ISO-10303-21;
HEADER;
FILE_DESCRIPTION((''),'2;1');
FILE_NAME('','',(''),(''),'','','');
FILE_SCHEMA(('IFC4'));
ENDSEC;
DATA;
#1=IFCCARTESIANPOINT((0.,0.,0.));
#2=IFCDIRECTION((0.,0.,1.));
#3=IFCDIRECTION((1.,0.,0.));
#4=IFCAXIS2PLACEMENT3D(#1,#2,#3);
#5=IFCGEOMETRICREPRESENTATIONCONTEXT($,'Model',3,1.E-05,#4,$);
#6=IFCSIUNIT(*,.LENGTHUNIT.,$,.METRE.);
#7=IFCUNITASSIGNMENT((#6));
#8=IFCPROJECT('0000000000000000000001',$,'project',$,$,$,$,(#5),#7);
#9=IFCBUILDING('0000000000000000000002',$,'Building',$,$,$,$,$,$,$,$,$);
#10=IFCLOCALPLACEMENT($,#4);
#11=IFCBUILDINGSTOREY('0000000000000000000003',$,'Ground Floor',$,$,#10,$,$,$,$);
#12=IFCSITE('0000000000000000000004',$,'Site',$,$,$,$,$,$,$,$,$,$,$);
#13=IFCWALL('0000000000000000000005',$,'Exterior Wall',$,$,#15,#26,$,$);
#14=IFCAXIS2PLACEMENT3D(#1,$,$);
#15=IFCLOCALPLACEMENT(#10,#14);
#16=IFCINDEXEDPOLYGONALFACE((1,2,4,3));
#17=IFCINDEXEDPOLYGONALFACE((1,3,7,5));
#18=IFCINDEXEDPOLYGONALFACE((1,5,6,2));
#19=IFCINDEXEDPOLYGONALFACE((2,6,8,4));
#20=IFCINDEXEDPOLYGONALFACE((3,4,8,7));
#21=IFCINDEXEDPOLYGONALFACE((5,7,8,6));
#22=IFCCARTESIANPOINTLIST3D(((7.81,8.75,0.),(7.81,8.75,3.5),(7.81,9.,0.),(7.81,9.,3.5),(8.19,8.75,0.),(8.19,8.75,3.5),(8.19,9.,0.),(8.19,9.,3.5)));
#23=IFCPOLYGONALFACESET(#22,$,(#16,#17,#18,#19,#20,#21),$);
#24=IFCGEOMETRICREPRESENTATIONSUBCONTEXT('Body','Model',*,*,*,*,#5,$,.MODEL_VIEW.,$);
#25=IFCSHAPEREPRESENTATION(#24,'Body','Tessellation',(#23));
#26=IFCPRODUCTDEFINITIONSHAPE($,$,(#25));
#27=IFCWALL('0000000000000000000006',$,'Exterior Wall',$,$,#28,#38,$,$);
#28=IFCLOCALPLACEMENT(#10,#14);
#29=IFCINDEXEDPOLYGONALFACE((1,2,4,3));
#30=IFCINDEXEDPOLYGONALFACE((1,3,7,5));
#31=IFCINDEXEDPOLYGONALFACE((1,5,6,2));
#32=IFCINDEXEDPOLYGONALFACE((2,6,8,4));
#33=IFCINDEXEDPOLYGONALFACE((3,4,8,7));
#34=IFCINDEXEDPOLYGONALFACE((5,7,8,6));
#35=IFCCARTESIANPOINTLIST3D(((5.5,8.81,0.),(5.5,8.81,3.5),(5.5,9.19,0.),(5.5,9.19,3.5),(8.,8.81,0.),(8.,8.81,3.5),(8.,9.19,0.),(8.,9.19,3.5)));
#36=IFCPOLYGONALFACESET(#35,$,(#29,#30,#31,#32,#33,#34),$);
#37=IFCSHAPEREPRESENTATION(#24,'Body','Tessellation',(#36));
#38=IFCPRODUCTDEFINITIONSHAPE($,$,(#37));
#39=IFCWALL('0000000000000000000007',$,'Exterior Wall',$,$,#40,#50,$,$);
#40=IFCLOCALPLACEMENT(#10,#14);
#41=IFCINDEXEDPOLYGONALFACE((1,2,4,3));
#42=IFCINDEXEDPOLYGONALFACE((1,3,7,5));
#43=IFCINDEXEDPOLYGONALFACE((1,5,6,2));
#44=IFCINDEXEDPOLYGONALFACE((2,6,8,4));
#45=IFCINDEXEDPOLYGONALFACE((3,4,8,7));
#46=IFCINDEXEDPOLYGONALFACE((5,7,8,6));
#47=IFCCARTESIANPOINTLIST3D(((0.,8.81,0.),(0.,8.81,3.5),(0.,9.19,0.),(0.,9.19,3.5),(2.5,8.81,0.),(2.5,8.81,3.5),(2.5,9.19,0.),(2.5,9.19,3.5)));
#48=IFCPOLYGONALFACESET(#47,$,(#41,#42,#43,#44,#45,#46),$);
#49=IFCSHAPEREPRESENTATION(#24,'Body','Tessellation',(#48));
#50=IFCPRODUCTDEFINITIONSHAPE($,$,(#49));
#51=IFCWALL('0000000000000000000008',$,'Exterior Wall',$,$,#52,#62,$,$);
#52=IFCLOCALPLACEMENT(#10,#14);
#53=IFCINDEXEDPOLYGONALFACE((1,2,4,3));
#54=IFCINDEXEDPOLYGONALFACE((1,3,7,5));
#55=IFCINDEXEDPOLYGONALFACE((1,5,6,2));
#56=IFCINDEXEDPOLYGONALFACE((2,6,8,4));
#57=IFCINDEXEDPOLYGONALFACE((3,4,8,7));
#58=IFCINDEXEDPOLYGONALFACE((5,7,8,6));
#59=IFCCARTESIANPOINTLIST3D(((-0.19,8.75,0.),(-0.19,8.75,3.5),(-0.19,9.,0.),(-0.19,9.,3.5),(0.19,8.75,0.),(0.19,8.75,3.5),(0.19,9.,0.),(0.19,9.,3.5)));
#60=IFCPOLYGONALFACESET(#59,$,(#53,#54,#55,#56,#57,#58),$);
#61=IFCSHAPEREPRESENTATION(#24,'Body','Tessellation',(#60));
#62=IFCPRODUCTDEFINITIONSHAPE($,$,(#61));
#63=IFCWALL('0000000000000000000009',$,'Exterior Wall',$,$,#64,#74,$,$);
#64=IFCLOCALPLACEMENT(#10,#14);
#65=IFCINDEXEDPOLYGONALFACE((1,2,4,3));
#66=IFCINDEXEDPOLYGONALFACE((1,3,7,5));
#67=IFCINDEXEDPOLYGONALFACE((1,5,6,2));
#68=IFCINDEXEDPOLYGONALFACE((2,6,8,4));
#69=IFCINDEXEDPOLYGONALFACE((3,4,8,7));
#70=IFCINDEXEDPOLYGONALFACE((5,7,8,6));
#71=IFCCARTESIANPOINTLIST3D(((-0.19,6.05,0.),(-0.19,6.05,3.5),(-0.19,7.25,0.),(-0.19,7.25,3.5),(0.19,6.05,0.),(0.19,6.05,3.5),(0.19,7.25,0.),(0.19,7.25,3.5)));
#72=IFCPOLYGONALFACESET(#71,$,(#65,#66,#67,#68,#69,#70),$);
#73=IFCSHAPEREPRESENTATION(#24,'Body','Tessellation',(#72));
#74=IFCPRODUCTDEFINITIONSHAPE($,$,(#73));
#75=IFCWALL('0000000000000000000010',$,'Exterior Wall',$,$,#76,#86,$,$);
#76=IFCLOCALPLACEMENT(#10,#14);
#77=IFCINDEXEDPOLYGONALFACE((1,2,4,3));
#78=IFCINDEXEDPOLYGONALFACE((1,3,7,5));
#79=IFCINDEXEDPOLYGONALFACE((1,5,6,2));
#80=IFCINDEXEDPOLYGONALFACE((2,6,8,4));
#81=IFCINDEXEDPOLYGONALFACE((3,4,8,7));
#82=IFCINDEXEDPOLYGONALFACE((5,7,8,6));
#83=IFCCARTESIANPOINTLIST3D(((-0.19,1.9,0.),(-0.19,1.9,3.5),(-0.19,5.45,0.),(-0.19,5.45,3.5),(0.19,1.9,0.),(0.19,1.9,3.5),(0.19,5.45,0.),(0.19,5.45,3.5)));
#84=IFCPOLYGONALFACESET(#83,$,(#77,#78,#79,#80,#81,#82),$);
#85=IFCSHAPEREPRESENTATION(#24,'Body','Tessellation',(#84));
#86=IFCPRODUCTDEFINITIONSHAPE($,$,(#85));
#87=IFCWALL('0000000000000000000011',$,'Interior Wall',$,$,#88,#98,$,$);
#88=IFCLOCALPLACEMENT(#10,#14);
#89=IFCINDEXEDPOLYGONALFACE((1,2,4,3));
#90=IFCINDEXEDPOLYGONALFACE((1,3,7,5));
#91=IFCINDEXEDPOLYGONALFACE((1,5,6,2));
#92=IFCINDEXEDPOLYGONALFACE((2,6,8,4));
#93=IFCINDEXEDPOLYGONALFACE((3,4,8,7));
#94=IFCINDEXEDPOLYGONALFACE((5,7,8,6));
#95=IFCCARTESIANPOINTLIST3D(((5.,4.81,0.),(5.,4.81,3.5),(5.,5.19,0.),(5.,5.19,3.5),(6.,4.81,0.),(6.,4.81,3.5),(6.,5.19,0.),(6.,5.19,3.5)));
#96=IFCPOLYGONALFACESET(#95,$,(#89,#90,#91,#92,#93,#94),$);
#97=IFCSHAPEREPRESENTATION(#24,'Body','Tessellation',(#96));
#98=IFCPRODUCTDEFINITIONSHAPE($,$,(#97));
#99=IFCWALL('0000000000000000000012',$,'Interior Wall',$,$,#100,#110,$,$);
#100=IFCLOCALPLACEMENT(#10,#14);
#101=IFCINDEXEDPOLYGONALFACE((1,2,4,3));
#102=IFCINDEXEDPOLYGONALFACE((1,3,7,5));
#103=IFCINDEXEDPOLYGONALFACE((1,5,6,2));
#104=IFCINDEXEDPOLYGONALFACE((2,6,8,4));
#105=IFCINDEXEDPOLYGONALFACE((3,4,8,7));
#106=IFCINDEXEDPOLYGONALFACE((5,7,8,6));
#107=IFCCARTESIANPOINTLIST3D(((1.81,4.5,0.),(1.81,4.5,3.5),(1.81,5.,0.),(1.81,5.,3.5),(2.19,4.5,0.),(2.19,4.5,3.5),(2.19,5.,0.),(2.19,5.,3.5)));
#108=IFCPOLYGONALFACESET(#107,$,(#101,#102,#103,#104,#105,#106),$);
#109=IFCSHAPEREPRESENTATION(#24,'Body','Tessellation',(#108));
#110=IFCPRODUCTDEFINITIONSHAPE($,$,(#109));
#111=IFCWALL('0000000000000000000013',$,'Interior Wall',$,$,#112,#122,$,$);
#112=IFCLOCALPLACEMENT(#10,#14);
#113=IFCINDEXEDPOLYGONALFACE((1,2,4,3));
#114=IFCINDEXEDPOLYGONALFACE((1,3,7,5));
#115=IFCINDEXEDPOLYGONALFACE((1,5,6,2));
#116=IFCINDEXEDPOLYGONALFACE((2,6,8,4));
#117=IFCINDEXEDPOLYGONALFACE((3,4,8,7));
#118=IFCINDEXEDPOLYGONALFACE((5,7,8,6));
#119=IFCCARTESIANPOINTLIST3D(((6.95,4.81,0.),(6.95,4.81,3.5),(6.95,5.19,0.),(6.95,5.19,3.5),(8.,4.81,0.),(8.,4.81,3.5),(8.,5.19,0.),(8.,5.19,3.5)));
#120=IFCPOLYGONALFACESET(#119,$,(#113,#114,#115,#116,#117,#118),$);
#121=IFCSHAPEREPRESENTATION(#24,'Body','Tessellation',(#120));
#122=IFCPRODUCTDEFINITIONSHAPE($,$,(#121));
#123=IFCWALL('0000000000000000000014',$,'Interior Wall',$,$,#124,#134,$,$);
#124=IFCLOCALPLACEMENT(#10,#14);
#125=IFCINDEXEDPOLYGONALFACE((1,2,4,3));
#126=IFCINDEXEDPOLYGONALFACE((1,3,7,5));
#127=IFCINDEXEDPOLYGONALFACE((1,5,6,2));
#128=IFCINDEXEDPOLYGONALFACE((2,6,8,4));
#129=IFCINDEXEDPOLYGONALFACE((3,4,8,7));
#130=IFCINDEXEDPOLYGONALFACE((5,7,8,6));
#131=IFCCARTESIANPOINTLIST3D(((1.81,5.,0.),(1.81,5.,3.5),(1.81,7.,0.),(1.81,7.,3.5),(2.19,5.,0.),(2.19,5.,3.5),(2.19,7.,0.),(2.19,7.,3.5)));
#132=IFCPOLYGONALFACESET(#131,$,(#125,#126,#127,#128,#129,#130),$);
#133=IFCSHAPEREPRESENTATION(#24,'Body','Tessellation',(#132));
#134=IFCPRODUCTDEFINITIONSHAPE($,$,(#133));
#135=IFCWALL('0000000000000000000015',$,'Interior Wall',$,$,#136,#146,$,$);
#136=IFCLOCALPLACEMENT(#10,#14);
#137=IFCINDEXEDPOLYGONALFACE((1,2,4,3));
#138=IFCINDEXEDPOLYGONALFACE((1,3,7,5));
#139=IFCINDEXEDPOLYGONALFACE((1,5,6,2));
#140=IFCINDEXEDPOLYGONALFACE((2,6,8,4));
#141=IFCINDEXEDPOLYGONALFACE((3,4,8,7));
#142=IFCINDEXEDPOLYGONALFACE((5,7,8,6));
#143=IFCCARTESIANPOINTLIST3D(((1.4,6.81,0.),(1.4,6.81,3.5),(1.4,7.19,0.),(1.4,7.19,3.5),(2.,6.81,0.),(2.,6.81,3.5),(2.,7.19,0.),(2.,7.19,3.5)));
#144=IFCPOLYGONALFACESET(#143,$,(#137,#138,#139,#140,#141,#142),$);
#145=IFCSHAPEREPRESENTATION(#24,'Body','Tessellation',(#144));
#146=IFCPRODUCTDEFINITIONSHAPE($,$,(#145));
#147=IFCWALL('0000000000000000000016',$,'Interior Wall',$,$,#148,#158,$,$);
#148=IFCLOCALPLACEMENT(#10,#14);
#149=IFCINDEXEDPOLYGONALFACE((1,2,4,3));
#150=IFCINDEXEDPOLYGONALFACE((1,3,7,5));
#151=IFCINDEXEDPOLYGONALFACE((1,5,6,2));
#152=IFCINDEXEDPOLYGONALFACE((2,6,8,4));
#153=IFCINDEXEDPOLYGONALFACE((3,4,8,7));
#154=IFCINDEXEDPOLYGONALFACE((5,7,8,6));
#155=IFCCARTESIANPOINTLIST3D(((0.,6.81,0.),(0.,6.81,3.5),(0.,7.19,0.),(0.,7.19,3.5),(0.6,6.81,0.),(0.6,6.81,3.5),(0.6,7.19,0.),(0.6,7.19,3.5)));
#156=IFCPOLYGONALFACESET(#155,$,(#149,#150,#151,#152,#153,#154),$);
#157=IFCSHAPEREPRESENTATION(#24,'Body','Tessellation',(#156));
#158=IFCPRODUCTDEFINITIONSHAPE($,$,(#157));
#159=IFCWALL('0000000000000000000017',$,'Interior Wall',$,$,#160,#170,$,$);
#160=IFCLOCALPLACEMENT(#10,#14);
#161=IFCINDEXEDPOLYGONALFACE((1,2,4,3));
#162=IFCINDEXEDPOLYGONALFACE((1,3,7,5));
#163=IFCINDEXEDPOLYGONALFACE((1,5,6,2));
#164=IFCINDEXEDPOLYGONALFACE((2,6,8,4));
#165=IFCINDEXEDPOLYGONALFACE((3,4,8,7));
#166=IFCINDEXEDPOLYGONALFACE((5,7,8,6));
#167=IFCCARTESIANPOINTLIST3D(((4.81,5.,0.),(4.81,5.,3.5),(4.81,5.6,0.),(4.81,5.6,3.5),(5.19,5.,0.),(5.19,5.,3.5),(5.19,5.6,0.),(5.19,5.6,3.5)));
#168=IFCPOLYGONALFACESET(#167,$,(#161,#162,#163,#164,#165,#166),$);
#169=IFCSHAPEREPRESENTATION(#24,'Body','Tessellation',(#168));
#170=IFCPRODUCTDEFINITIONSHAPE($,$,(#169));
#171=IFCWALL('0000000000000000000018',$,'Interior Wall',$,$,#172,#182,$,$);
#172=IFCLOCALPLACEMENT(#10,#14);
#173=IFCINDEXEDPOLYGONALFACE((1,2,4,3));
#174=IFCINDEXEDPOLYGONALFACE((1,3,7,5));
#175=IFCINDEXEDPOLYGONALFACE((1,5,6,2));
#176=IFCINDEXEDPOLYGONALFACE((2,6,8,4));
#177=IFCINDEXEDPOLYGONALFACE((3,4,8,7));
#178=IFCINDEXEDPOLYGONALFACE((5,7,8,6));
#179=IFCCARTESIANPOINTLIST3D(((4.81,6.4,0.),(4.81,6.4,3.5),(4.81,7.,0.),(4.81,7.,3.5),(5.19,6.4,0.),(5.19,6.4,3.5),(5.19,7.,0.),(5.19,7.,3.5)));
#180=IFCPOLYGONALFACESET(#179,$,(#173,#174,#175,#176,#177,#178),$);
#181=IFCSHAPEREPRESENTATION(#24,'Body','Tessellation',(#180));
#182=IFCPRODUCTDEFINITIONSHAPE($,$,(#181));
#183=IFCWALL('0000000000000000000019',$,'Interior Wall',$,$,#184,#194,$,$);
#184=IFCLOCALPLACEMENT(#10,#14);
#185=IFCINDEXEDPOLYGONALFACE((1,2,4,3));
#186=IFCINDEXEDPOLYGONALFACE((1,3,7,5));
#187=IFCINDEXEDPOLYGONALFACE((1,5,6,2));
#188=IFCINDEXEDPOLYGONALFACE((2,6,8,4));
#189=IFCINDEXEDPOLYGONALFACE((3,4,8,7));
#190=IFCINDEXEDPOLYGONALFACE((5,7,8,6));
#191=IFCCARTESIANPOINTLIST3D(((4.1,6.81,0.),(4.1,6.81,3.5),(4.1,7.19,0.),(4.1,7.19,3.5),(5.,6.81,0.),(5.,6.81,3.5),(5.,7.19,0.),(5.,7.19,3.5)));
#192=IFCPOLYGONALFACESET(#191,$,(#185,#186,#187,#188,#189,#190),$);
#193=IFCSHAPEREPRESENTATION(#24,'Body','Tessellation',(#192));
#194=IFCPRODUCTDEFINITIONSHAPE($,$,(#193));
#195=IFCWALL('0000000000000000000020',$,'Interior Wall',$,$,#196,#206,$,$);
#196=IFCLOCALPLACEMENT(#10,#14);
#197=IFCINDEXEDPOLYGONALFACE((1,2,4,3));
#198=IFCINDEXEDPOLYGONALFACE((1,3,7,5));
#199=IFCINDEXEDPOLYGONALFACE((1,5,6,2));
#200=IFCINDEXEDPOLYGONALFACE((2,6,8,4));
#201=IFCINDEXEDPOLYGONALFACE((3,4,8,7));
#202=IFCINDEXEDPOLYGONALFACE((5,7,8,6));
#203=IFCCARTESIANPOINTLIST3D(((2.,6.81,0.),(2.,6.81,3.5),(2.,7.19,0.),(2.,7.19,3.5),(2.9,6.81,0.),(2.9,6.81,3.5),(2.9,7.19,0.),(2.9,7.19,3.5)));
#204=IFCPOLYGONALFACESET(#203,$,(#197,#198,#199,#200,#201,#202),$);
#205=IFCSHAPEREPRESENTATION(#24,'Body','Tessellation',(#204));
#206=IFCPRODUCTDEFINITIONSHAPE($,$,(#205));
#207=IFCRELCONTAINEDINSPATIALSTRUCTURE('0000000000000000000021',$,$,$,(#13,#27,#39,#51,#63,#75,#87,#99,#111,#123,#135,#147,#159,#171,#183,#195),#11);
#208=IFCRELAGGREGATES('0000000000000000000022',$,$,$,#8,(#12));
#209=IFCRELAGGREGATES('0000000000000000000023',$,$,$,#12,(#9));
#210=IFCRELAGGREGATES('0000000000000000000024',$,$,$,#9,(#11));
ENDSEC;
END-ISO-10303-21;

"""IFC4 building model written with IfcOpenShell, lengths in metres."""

from ifc_helpers import new_model, si_unit, frame, origin_with_axes, place, context, subcontext, project, spatial, indexed_curve, outline, extrude, element, save


model = new_model("IFC4")

# Units and contexts
model_context = context("Model", 3, precision=1e-05, world=origin_with_axes())
body_context = subcontext(model_context, "Body", "Model", "MODEL_VIEW")
ifc_project = project(units=[si_unit("LENGTHUNIT", "METRE")], contexts=[model_context])

# Site, building, storey
site = spatial("IfcSite", under=ifc_project, Name="Site")
building = spatial("IfcBuilding", under=site, Name="Building")
storey_placement = place(None, origin_with_axes())
storey = spatial("IfcBuildingStorey", under=building, at=storey_placement, Name="Ground Floor")

# Walls
wall_1_placement = place(storey_placement, frame((8.0, 8.75, 0.0), z_axis=(0.0, 0.0, 1.0), x_axis=(0.0, 1.0, 0.0)))
element("IfcWall", 1, at=wall_1_placement, inside=storey, Name="Exterior Wall", context=body_context, shape_type="SweptSolid", body=[
    extrude(outline(indexed_curve([(0.0, 0.0), (0.0, 0.38), (0.25, 0.38), (0.25, 0.0), (0.0, 0.0)], self_intersect=False)), frame((0.0, -0.19, 0.0), z_axis=(0.0, 0.0, 1.0), x_axis=(1.0, 0.0, 0.0)), (0.0, 0.0, 1.0), 3.5),
])
for number, where, z_axis, x_axis, name in (
    (2, (8.0, 9.0, 0.0), (0.0, 0.0, 1.0), (-1.0, 0.0, 0.0), "Exterior Wall"),
    (3, (2.5, 9.0, 0.0), (0.0, 0.0, 1.0), (-1.0, 0.0, 0.0), "Exterior Wall"),
):
    element("IfcWall", number, at=place(storey_placement, frame(where, z_axis=z_axis, x_axis=x_axis)), inside=storey, Name=name, context=body_context, shape_type="SweptSolid", body=[
        extrude(outline(indexed_curve([(0.0, 0.0), (0.0, 0.38), (2.5, 0.38), (2.5, 0.0), (0.0, 0.0)], self_intersect=False)), frame((0.0, -0.19, 0.0), z_axis=(0.0, 0.0, 1.0), x_axis=(1.0, 0.0, 0.0)), (0.0, 0.0, 1.0), 3.5),
    ])
wall_2_placement = place(storey_placement, frame((0.0, 9.0, 0.0), z_axis=(0.0, 0.0, 1.0), x_axis=(0.0, -1.0, 0.0)))
element("IfcWall", 4, at=wall_2_placement, inside=storey, Name="Exterior Wall", context=body_context, shape_type="SweptSolid", body=[
    extrude(outline(indexed_curve([(0.0, 0.0), (0.0, 0.38), (0.25, 0.38), (0.25, 0.0), (0.0, 0.0)], self_intersect=False)), frame((0.0, -0.19, 0.0), z_axis=(0.0, 0.0, 1.0), x_axis=(1.0, 0.0, 0.0)), (0.0, 0.0, 1.0), 3.5),
])
wall_3_placement = place(storey_placement, frame((0.0, 7.25, 0.0), z_axis=(0.0, 0.0, 1.0), x_axis=(0.0, -1.0, 0.0)))
element("IfcWall", 5, at=wall_3_placement, inside=storey, Name="Exterior Wall", context=body_context, shape_type="SweptSolid", body=[
    extrude(outline(indexed_curve([(0.0, 0.0), (0.0, 0.38), (1.2, 0.38), (1.2, 0.0), (0.0, 0.0)], self_intersect=False)), frame((0.0, -0.19, 0.0), z_axis=(0.0, 0.0, 1.0), x_axis=(1.0, 0.0, 0.0)), (0.0, 0.0, 1.0), 3.5),
])
wall_4_placement = place(storey_placement, frame((0.0, 5.45, 0.0), z_axis=(0.0, 0.0, 1.0), x_axis=(0.0, -1.0, 0.0)))
element("IfcWall", 6, at=wall_4_placement, inside=storey, Name="Exterior Wall", context=body_context, shape_type="SweptSolid", body=[
    extrude(outline(indexed_curve([(0.0, 0.0), (0.0, 0.38), (3.55, 0.38), (3.55, 0.0), (0.0, 0.0)], self_intersect=False)), frame((0.0, -0.19, 0.0), z_axis=(0.0, 0.0, 1.0), x_axis=(1.0, 0.0, 0.0)), (0.0, 0.0, 1.0), 3.5),
])
wall_5_placement = place(storey_placement, frame((6.0, 5.0, 0.0), z_axis=(0.0, 0.0, 1.0), x_axis=(-1.0, 0.0, 0.0)))
element("IfcWall", 7, at=wall_5_placement, inside=storey, Name="Interior Wall", context=body_context, shape_type="SweptSolid", body=[
    extrude(outline(indexed_curve([(0.0, 0.0), (0.0, 0.38), (1.0, 0.38), (1.0, 0.0), (0.0, 0.0)], self_intersect=False)), frame((0.0, -0.19, 0.0), z_axis=(0.0, 0.0, 1.0), x_axis=(1.0, 0.0, 0.0)), (0.0, 0.0, 1.0), 3.5),
])
wall_6_placement = place(storey_placement, frame((2.0, 5.0, 0.0), z_axis=(0.0, 0.0, 1.0), x_axis=(0.0, -1.0, 0.0)))
element("IfcWall", 8, at=wall_6_placement, inside=storey, Name="Interior Wall", context=body_context, shape_type="SweptSolid", body=[
    extrude(outline(indexed_curve([(0.0, 0.0), (0.0, 0.38), (0.5, 0.38), (0.5, 0.0), (0.0, 0.0)], self_intersect=False)), frame((0.0, -0.19, 0.0), z_axis=(0.0, 0.0, 1.0), x_axis=(1.0, 0.0, 0.0)), (0.0, 0.0, 1.0), 3.5),
])
wall_7_placement = place(storey_placement, frame((8.0, 5.0, 0.0), z_axis=(0.0, 0.0, 1.0), x_axis=(-1.0, 0.0, 0.0)))
element("IfcWall", 9, at=wall_7_placement, inside=storey, Name="Interior Wall", context=body_context, shape_type="SweptSolid", body=[
    extrude(outline(indexed_curve([(0.0, 0.0), (0.0, 0.38), (1.05, 0.38), (1.05, 0.0), (0.0, 0.0)], self_intersect=False)), frame((0.0, -0.19, 0.0), z_axis=(0.0, 0.0, 1.0), x_axis=(1.0, 0.0, 0.0)), (0.0, 0.0, 1.0), 3.5),
])
wall_8_placement = place(storey_placement, frame((2.0, 5.0, 0.0), z_axis=(0.0, 0.0, 1.0), x_axis=(0.0, 1.0, 0.0)))
element("IfcWall", 10, at=wall_8_placement, inside=storey, Name="Interior Wall", context=body_context, shape_type="SweptSolid", body=[
    extrude(outline(indexed_curve([(0.0, 0.0), (0.0, 0.38), (2.0, 0.38), (2.0, 0.0), (0.0, 0.0)], self_intersect=False)), frame((0.0, -0.19, 0.0), z_axis=(0.0, 0.0, 1.0), x_axis=(1.0, 0.0, 0.0)), (0.0, 0.0, 1.0), 3.5),
])
for number, where, z_axis, x_axis, name in (
    (11, (2.0, 7.0, 0.0), (0.0, 0.0, 1.0), (-1.0, 0.0, 0.0), "Interior Wall"),
    (12, (0.6, 7.0, 0.0), (0.0, 0.0, 1.0), (-1.0, 0.0, 0.0), "Interior Wall"),
):
    element("IfcWall", number, at=place(storey_placement, frame(where, z_axis=z_axis, x_axis=x_axis)), inside=storey, Name=name, context=body_context, shape_type="SweptSolid", body=[
        extrude(outline(indexed_curve([(0.0, 0.0), (0.0, 0.38), (0.6, 0.38), (0.6, 0.0), (0.0, 0.0)], self_intersect=False)), frame((0.0, -0.19, 0.0), z_axis=(0.0, 0.0, 1.0), x_axis=(1.0, 0.0, 0.0)), (0.0, 0.0, 1.0), 3.5),
    ])
for number, where, z_axis, x_axis, name in (
    (13, (5.0, 5.0, 0.0), (0.0, 0.0, 1.0), (0.0, 1.0, 0.0), "Interior Wall"),
    (14, (5.0, 6.4, 0.0), (0.0, 0.0, 1.0), (0.0, 1.0, 0.0), "Interior Wall"),
):
    element("IfcWall", number, at=place(storey_placement, frame(where, z_axis=z_axis, x_axis=x_axis)), inside=storey, Name=name, context=body_context, shape_type="SweptSolid", body=[
        extrude(outline(indexed_curve([(0.0, 0.0), (0.0, 0.38), (0.6, 0.38), (0.6, 0.0), (0.0, 0.0)], self_intersect=False)), frame((0.0, -0.19, 0.0), z_axis=(0.0, 0.0, 1.0), x_axis=(1.0, 0.0, 0.0)), (0.0, 0.0, 1.0), 3.5),
    ])
wall_9_placement = place(storey_placement, frame((5.0, 7.0, 0.0), z_axis=(0.0, 0.0, 1.0), x_axis=(-1.0, 0.0, 0.0)))
element("IfcWall", 15, at=wall_9_placement, inside=storey, Name="Interior Wall", context=body_context, shape_type="SweptSolid", body=[
    extrude(outline(indexed_curve([(0.0, 0.0), (0.0, 0.38), (0.9, 0.38), (0.9, 0.0), (0.0, 0.0)], self_intersect=False)), frame((0.0, -0.19, 0.0), z_axis=(0.0, 0.0, 1.0), x_axis=(1.0, 0.0, 0.0)), (0.0, 0.0, 1.0), 3.5),
])
wall_10_placement = place(storey_placement, frame((2.9, 7.0, 0.0), z_axis=(0.0, 0.0, 1.0), x_axis=(-1.0, 0.0, 0.0)))
element("IfcWall", 16, at=wall_10_placement, inside=storey, Name="Interior Wall", context=body_context, shape_type="SweptSolid", body=[
    extrude(outline(indexed_curve([(0.0, 0.0), (0.0, 0.38), (0.9, 0.38), (0.9, 0.0), (0.0, 0.0)], self_intersect=False)), frame((0.0, -0.19, 0.0), z_axis=(0.0, 0.0, 1.0), x_axis=(1.0, 0.0, 0.0)), (0.0, 0.0, 1.0), 3.5),
])

save(model, "model.ifc")
